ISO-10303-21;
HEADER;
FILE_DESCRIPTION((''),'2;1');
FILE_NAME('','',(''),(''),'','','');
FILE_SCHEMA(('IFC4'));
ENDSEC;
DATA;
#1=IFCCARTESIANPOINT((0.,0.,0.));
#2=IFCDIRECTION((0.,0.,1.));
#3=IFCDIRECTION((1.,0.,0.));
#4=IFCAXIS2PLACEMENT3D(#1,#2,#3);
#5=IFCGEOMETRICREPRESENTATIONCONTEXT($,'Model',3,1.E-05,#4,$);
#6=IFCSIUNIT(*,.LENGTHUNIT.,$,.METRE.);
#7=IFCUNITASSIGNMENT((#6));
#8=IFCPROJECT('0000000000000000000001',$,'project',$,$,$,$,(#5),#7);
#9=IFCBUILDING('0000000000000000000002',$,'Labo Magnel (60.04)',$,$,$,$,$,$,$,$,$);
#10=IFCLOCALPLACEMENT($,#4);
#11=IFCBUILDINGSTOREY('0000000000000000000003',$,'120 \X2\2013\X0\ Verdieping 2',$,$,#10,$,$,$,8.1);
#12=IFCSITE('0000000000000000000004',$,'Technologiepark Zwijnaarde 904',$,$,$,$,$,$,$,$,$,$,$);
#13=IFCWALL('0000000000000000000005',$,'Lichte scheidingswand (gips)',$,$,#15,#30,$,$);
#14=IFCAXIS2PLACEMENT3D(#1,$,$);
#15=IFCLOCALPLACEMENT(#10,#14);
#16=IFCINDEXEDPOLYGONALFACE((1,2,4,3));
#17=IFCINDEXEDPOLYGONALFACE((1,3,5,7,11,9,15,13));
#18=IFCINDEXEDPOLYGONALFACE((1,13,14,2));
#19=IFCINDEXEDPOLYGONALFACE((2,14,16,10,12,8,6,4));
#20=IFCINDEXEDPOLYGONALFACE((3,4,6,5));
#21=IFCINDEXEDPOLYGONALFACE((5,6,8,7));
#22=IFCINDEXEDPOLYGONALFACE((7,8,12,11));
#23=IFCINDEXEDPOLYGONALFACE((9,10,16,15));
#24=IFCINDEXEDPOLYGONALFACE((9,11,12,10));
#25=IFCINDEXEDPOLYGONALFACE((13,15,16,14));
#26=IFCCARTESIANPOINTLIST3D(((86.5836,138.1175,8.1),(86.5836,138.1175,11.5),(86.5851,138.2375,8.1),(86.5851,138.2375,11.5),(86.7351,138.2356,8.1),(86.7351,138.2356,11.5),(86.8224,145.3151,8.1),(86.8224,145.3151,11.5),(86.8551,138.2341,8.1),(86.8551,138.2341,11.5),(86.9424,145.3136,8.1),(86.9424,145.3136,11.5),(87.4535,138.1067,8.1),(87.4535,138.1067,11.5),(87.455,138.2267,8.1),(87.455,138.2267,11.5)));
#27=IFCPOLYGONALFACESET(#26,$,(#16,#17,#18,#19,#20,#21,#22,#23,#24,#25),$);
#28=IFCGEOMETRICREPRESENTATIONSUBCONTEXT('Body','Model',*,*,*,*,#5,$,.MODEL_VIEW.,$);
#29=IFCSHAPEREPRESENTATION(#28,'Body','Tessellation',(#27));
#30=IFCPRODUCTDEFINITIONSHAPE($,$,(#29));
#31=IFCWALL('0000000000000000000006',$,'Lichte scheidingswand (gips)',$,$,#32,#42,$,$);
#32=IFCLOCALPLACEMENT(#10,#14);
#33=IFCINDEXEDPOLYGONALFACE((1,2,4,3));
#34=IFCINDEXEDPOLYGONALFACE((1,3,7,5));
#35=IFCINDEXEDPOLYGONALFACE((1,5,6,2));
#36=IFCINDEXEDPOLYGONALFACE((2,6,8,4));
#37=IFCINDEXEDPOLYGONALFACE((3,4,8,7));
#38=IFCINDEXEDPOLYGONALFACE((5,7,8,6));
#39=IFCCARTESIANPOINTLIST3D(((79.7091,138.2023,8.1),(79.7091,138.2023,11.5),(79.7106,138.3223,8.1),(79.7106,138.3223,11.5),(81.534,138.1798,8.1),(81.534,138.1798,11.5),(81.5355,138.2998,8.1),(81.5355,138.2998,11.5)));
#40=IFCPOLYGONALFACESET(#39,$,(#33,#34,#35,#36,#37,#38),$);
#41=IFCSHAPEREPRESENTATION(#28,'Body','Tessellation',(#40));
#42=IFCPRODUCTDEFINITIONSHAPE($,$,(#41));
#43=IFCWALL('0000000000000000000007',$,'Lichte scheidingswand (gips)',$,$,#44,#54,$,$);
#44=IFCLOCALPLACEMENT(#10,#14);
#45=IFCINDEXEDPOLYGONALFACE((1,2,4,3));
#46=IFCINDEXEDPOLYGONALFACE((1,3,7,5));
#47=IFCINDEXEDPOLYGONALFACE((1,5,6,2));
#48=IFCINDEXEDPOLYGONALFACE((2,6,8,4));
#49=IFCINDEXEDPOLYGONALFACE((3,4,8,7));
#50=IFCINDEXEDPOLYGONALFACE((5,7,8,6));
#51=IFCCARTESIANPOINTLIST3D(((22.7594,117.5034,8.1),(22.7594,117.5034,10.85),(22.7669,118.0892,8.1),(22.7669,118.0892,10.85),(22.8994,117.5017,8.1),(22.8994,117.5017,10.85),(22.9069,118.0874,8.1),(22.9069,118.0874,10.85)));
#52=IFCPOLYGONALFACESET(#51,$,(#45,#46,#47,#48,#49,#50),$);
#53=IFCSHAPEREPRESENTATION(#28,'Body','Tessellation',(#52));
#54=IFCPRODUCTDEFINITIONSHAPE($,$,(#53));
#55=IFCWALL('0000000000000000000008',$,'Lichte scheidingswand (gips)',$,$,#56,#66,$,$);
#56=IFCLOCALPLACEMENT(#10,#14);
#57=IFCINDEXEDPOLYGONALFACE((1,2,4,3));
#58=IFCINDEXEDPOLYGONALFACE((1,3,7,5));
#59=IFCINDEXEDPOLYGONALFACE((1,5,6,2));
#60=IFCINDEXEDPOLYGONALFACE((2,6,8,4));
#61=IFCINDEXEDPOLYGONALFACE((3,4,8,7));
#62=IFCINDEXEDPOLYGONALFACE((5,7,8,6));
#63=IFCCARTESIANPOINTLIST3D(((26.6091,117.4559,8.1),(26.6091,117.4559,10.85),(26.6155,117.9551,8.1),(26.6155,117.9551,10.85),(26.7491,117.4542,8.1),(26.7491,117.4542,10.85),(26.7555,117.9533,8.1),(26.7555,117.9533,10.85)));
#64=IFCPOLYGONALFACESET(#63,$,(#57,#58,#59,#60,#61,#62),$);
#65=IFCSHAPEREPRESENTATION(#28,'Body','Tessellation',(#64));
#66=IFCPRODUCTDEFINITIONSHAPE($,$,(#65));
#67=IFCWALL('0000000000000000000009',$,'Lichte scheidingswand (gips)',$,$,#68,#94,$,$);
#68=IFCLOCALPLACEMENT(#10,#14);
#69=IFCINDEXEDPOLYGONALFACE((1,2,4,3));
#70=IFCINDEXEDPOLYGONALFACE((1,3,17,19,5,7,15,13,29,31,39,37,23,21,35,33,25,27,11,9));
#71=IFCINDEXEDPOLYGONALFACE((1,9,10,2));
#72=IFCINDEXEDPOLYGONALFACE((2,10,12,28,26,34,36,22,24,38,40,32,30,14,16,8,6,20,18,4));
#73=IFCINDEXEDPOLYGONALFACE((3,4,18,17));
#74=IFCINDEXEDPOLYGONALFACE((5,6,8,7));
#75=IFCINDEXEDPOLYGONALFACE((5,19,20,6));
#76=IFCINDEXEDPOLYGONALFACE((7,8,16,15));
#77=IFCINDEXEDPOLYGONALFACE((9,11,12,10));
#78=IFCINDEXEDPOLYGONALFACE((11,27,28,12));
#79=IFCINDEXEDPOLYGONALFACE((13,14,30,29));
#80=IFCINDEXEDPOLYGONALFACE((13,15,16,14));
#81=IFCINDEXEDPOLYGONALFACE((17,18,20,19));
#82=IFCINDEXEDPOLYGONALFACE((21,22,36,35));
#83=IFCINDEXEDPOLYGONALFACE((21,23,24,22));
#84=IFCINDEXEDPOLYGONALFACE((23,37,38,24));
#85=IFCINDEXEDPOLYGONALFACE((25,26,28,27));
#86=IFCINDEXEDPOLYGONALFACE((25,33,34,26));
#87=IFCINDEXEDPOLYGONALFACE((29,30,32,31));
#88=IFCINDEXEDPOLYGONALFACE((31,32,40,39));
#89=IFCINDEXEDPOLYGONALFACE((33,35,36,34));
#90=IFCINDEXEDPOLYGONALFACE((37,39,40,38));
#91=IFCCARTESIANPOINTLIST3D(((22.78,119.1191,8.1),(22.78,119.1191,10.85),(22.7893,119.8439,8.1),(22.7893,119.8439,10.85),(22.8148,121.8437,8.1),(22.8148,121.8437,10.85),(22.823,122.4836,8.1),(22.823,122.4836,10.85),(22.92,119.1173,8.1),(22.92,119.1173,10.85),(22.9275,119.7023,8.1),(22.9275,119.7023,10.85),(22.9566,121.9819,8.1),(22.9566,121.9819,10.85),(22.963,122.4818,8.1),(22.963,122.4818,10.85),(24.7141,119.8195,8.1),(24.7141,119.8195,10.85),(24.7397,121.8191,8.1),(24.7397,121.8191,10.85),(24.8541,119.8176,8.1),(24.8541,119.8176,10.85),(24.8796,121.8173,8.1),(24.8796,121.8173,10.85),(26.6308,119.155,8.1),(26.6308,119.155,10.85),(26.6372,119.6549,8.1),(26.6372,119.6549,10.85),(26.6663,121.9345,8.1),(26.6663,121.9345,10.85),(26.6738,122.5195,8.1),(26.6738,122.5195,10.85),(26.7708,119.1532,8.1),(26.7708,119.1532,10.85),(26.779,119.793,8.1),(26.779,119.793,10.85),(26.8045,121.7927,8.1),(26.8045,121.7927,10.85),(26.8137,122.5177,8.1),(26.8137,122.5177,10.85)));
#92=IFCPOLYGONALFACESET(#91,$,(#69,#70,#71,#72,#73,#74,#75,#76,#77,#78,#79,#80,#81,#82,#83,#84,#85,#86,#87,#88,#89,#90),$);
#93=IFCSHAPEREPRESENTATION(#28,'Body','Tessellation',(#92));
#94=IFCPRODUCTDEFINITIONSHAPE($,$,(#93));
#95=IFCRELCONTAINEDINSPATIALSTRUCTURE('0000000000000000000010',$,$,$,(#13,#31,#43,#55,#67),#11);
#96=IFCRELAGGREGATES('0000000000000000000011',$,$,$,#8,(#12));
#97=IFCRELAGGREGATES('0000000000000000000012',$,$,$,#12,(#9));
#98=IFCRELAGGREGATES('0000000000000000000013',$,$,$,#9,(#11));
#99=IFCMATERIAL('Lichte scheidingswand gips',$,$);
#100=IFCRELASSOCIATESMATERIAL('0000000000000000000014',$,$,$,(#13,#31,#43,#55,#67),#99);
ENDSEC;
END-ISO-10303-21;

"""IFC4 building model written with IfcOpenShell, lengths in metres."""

from ifc_helpers import new_model, si_unit, frame, origin, origin_with_axes, place, context, subcontext, project, spatial, polyline, outline, extrude, material, element, save


model = new_model("IFC4")

# Units and contexts
model_context = context("Model", 3, precision=1e-05, world=origin_with_axes())
body_context = subcontext(model_context, "Body", "Model", "MODEL_VIEW")
ifc_project = project(units=[si_unit("LENGTHUNIT", "METRE")], contexts=[model_context])

# Site, building, storey
site = spatial("IfcSite", under=ifc_project, Name="Technologiepark Zwijnaarde 904")
building = spatial("IfcBuilding", under=site, Name="Labo Magnel (60.04)")
storey_placement = place(None, origin_with_axes())
storey = spatial("IfcBuildingStorey", under=building, at=storey_placement, Name="120 – Verdieping 2", Elevation=8.1)

# Walls
ifc_material_1 = material(Name="Lichte scheidingswand gips")
wall_1_placement = place(storey_placement, frame((0.0, 0.0, 8.1), z_axis=(0.0, 0.0, 1.0), x_axis=(1.0, 0.0, 0.0)))
element("IfcWall", 1, at=wall_1_placement, inside=storey, material=ifc_material_1, Name="Lichte scheidingswand (gips)", context=body_context, shape_type="SweptSolid", body=[
    extrude(outline(polyline([(86.5851, 138.2375), (86.5836, 138.1175), (87.4535, 138.1067), (87.455, 138.2267), (86.8551, 138.2341), (86.9424, 145.3136), (86.8224, 145.3151), (86.7351, 138.2356), (86.5851, 138.2375)])), origin(), (0.0, 0.0, 1.0), 3.4),
])
wall_2_placement = place(storey_placement, frame((0.0, 0.0, 8.1), z_axis=(0.0, 0.0, 1.0), x_axis=(1.0, 0.0, 0.0)))
element("IfcWall", 2, at=wall_2_placement, inside=storey, material=ifc_material_1, Name="Lichte scheidingswand (gips)", context=body_context, shape_type="SweptSolid", body=[
    extrude(outline(polyline([(81.5355, 138.2998), (79.7106, 138.3223), (79.7091, 138.2023), (81.534, 138.1798), (81.5355, 138.2998)])), origin(), (0.0, 0.0, 1.0), 3.4),
])
wall_3_placement = place(storey_placement, frame((0.0, 0.0, 8.1), z_axis=(0.0, 0.0, 1.0), x_axis=(1.0, 0.0, 0.0)))
element("IfcWall", 3, at=wall_3_placement, inside=storey, material=ifc_material_1, Name="Lichte scheidingswand (gips)", context=body_context, shape_type="SweptSolid", body=[
    extrude(outline(polyline([(22.7594, 117.5034), (22.7669, 118.0892), (22.9069, 118.0874), (22.8994, 117.5017), (22.7594, 117.5034)])), origin(), (0.0, 0.0, 1.0), 2.75),
])
wall_4_placement = place(storey_placement, frame((0.0, 0.0, 8.1), z_axis=(0.0, 0.0, 1.0), x_axis=(1.0, 0.0, 0.0)))
element("IfcWall", 4, at=wall_4_placement, inside=storey, material=ifc_material_1, Name="Lichte scheidingswand (gips)", context=body_context, shape_type="SweptSolid", body=[
    extrude(outline(polyline([(26.6155, 117.9551), (26.7555, 117.9533), (26.7491, 117.4542), (26.6091, 117.4559), (26.6155, 117.9551)])), origin(), (0.0, 0.0, 1.0), 2.75),
])
wall_5_placement = place(storey_placement, frame((0.0, 0.0, 8.1), z_axis=(0.0, 0.0, 1.0), x_axis=(1.0, 0.0, 0.0)))
element("IfcWall", 5, at=wall_5_placement, inside=storey, material=ifc_material_1, Name="Lichte scheidingswand (gips)", context=body_context, shape_type="SweptSolid", body=[
    extrude(outline(polyline([(22.7893, 119.8439), (24.7141, 119.8195), (24.7397, 121.8191), (22.8148, 121.8437), (22.823, 122.4836), (22.963, 122.4818), (22.9566, 121.9819), (26.6663, 121.9345), (26.6738, 122.5195), (26.8137, 122.5177), (26.8045, 121.7927), (24.8796, 121.8173), (24.8541, 119.8176), (26.779, 119.793), (26.7708, 119.1532), (26.6308, 119.155), (26.6372, 119.6549), (22.9275, 119.7023), (22.92, 119.1173), (22.78, 119.1191), (22.7893, 119.8439)])), origin(), (0.0, 0.0, 1.0), 2.75),
])

save(model, "model.ifc")
